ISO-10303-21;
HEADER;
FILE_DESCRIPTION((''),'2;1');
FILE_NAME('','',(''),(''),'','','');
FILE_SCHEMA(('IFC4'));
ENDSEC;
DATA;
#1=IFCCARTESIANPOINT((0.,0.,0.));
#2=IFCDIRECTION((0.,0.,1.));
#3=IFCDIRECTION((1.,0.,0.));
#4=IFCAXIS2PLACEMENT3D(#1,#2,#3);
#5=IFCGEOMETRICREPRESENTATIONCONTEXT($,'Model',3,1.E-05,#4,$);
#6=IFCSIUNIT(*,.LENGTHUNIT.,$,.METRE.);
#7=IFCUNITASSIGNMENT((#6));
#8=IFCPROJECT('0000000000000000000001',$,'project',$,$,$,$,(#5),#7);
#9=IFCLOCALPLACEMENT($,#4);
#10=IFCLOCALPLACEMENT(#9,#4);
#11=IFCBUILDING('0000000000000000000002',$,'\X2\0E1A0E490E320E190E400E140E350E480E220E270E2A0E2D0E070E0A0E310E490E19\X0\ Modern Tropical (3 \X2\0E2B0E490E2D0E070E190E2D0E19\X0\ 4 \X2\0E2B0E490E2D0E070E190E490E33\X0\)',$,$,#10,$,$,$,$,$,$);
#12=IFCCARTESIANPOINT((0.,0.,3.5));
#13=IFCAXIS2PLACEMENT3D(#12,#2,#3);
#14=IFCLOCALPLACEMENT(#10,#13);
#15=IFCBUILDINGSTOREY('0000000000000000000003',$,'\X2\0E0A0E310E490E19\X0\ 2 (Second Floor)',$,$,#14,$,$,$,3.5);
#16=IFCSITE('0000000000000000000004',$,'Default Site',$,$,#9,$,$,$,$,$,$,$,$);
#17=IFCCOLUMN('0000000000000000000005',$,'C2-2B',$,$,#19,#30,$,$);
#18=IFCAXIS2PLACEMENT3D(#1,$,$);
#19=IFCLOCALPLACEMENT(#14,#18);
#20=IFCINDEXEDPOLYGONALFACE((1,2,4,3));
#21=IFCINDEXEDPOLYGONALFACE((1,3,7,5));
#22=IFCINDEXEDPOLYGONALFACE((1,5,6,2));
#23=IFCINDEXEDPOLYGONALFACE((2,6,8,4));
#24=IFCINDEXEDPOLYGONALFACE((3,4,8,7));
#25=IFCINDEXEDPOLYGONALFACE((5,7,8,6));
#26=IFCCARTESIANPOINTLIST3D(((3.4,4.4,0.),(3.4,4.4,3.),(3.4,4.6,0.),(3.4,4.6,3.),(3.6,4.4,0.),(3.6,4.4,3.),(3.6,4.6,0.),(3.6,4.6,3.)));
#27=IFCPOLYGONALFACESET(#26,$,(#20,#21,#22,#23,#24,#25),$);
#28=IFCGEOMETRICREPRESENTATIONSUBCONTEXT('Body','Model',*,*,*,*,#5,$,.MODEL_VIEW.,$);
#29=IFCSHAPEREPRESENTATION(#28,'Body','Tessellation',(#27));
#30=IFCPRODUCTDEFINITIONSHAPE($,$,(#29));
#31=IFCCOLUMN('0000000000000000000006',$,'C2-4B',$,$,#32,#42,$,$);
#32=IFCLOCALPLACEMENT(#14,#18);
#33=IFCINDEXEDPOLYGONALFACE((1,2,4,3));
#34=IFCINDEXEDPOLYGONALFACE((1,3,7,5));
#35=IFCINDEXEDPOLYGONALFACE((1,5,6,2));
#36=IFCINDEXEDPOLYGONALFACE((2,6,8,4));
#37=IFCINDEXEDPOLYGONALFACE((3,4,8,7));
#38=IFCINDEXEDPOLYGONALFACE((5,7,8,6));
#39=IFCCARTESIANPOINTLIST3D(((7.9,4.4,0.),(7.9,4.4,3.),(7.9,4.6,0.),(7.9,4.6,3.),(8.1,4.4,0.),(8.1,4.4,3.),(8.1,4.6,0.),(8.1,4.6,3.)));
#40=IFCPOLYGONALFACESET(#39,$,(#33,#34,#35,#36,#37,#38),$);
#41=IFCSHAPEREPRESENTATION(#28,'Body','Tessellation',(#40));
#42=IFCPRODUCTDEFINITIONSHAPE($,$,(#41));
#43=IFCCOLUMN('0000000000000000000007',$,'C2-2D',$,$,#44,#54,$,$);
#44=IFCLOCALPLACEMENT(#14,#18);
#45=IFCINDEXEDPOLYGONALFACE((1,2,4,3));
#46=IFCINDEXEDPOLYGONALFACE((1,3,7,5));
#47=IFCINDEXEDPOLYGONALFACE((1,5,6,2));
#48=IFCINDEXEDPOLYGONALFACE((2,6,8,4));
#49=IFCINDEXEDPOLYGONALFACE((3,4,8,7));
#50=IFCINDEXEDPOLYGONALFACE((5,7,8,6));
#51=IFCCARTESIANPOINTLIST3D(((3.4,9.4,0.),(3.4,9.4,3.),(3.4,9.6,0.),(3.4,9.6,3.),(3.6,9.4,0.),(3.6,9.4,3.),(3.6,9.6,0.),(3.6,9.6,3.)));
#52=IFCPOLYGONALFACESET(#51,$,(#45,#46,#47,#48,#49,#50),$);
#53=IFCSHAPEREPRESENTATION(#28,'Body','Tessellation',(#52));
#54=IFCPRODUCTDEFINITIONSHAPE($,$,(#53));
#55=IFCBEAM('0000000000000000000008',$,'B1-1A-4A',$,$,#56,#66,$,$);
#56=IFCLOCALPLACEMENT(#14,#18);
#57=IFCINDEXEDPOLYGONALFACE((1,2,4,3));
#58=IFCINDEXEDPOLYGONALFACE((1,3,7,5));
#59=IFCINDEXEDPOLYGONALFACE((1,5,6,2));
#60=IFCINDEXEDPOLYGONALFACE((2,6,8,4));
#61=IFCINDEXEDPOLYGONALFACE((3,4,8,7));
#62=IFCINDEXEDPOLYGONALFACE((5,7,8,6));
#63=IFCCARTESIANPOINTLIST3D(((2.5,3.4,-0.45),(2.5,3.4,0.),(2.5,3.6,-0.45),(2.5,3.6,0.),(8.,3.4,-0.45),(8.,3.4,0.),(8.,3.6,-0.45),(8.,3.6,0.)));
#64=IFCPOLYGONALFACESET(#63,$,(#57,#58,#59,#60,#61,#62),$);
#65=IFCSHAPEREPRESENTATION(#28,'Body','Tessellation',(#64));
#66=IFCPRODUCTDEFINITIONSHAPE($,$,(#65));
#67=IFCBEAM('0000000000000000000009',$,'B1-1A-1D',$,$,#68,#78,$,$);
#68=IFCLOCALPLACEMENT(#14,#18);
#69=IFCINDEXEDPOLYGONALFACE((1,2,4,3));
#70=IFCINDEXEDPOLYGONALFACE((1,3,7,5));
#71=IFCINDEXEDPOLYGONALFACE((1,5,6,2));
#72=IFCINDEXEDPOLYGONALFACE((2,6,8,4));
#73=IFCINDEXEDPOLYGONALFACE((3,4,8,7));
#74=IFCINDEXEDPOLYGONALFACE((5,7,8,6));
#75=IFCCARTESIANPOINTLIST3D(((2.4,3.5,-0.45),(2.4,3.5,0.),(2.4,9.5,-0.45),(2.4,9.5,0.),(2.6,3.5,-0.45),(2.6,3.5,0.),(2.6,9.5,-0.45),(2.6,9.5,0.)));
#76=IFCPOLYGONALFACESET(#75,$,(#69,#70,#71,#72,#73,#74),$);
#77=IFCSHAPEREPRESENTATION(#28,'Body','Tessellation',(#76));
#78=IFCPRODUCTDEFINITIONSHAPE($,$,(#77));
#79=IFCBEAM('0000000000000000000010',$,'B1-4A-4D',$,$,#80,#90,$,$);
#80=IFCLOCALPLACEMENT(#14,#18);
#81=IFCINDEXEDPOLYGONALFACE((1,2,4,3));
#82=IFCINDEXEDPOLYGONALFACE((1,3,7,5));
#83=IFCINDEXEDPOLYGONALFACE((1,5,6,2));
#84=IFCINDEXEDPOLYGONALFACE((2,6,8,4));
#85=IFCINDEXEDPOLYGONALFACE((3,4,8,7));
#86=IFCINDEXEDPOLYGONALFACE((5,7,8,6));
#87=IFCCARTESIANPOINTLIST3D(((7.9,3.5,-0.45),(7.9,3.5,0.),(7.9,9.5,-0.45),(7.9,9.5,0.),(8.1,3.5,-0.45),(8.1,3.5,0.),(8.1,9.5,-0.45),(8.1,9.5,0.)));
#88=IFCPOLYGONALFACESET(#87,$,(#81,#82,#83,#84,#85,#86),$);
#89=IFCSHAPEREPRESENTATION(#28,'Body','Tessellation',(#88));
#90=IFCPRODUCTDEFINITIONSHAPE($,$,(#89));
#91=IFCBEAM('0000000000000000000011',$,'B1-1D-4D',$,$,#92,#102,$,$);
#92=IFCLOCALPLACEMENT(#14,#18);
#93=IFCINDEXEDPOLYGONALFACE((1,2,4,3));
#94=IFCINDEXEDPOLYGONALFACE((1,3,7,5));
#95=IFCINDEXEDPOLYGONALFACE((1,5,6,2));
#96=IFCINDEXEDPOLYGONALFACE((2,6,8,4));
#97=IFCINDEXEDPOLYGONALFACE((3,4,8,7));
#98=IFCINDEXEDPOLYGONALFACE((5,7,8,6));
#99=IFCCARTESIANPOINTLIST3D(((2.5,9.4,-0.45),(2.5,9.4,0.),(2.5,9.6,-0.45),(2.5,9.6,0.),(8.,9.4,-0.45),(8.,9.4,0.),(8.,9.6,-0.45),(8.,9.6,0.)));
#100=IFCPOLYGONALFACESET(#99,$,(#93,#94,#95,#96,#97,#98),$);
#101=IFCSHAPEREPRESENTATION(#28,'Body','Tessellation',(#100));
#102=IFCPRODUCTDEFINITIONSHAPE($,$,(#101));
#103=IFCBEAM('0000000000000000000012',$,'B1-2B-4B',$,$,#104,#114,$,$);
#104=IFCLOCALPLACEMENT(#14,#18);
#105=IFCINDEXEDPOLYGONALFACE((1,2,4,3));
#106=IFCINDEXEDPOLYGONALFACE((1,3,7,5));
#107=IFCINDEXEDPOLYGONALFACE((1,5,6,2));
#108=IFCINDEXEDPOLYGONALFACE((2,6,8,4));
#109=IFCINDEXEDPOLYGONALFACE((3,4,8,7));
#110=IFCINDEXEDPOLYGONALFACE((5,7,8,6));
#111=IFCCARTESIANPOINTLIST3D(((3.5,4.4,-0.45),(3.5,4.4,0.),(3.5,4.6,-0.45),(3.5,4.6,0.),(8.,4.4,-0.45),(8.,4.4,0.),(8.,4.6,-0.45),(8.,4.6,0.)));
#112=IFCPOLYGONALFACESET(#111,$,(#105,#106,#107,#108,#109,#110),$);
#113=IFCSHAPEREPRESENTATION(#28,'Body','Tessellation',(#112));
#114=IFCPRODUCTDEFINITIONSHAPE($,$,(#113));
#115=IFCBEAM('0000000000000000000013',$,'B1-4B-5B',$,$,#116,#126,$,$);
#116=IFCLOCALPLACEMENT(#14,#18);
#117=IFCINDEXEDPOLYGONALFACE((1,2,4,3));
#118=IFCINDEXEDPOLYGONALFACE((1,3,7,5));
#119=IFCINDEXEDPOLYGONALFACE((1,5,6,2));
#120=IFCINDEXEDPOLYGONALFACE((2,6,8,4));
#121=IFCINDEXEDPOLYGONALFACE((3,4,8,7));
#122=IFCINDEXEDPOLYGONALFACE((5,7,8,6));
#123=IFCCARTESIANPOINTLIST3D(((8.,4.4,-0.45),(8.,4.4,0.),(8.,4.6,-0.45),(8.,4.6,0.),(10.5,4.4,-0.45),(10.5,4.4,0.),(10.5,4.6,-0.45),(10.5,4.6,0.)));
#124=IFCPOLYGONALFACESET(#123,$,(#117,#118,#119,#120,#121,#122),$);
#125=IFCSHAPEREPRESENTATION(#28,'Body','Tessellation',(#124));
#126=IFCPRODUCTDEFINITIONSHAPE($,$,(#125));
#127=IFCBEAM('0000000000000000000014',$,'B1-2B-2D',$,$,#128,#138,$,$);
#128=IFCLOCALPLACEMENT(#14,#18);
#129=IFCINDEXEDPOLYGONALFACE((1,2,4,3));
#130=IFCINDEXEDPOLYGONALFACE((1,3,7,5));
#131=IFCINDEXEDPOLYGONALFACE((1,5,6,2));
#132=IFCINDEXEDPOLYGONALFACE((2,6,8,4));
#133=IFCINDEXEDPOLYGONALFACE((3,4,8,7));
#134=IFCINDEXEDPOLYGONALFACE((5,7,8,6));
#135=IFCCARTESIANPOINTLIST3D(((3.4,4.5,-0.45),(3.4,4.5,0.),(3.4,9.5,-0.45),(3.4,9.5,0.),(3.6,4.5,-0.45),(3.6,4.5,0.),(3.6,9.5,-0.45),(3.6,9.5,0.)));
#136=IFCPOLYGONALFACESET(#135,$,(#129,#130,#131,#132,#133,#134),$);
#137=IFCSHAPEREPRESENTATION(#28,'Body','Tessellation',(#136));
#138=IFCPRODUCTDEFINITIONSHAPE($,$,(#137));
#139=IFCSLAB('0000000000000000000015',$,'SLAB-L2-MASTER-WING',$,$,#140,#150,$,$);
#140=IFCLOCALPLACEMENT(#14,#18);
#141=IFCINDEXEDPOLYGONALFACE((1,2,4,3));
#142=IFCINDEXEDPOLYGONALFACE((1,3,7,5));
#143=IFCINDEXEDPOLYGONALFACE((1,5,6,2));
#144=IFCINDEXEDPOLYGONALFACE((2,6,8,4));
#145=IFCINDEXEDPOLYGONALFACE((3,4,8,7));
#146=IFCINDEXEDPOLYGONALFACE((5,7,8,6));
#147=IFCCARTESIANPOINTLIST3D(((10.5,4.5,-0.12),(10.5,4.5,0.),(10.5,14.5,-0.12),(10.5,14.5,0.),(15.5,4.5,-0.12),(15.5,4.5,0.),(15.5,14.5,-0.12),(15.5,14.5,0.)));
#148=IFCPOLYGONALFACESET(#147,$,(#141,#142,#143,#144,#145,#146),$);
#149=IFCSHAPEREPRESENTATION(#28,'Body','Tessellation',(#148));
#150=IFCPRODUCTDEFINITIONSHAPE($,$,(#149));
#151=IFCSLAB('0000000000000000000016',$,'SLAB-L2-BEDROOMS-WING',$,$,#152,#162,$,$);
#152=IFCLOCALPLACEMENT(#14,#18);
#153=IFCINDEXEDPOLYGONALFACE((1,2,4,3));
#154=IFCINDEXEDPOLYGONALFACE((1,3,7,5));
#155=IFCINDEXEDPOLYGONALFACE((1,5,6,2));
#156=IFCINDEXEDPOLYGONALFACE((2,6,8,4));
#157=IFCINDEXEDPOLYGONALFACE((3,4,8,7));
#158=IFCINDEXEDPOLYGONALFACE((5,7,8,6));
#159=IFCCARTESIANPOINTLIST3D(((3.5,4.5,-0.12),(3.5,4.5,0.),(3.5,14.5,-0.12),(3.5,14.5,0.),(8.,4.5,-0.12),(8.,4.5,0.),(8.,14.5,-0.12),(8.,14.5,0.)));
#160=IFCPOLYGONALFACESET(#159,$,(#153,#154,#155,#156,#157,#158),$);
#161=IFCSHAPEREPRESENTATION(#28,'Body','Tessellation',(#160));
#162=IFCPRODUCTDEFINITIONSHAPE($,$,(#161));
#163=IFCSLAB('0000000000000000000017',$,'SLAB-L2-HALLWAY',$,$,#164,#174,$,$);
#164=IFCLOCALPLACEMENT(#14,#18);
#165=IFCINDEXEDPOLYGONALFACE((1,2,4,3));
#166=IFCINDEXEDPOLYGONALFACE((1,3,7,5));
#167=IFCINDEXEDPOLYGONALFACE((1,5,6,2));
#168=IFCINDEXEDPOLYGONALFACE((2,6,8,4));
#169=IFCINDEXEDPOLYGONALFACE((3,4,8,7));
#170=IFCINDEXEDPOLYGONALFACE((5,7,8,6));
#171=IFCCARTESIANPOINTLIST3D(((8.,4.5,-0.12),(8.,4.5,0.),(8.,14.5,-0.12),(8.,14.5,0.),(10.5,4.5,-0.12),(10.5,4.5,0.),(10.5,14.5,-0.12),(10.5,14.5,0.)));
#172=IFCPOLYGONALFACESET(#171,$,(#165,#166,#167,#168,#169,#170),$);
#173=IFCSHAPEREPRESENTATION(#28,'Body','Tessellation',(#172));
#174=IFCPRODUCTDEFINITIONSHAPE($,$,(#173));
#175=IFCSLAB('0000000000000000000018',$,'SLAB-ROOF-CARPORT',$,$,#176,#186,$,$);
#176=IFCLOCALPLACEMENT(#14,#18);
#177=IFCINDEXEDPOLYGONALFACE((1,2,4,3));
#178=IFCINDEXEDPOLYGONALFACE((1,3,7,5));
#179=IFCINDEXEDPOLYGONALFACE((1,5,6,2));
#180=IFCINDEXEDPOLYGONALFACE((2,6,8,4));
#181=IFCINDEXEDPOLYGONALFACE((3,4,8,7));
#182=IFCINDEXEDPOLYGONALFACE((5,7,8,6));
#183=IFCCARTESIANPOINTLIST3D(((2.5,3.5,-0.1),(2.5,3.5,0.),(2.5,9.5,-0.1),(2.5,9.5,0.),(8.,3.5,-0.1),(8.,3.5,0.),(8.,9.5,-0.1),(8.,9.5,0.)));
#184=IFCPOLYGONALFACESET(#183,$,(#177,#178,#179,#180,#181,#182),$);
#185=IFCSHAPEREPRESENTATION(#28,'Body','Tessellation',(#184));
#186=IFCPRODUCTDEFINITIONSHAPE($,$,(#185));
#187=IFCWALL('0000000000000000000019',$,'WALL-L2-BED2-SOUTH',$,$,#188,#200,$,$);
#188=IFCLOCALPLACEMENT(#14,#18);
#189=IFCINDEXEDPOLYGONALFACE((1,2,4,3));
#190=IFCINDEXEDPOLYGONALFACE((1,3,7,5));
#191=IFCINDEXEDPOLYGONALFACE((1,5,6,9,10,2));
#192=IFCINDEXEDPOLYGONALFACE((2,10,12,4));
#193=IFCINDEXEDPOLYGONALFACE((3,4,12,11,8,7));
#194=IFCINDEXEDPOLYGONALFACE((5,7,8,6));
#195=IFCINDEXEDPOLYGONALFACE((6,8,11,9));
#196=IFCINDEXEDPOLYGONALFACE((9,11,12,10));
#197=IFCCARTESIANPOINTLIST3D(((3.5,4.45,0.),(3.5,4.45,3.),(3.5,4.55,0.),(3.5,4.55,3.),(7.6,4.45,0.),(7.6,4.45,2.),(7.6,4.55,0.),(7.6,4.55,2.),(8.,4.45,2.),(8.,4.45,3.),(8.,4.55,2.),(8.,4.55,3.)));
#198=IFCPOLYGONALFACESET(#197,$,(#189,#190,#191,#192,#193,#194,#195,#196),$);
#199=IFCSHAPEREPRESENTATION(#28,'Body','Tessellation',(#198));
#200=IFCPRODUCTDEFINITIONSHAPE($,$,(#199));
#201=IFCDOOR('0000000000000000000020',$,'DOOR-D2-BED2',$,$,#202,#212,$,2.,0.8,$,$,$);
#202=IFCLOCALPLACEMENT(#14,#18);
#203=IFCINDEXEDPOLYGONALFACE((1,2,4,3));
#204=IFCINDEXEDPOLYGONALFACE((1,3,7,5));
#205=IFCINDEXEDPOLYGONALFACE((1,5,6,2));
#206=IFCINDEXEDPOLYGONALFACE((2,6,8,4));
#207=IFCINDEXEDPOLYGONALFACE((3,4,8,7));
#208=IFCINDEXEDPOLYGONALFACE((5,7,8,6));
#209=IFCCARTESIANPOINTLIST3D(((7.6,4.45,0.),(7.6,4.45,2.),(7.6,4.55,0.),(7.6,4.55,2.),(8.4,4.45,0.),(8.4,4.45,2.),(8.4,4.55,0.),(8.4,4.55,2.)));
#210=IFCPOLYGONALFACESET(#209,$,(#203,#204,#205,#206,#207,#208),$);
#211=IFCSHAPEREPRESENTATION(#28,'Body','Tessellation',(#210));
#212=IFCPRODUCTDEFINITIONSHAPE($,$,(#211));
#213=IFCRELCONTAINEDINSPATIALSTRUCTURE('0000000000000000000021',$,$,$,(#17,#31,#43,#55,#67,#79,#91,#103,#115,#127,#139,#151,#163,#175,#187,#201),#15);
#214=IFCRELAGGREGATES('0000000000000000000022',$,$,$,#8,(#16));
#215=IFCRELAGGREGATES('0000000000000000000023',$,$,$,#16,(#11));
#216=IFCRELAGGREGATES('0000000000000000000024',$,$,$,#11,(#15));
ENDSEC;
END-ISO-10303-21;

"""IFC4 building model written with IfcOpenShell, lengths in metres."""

from ifc_helpers import new_model, si_unit, frame, origin_with_axes, origin_2d, place, context, subcontext, project, spatial, polyline, rectangle, outline, extrude, element, fill, save


model = new_model("IFC4")

# Units and contexts
model_context = context("Model", 3, precision=1e-05, world=origin_with_axes())
body_context = subcontext(model_context, "Body", "Model", "MODEL_VIEW")
ifc_project = project(units=[si_unit("LENGTHUNIT", "METRE")], contexts=[model_context])

# Site, building, storey
site_placement = place(None, origin_with_axes())
site = spatial("IfcSite", under=ifc_project, at=site_placement, Name="Default Site")
building_placement = place(site_placement, origin_with_axes())
building = spatial("IfcBuilding", under=site, at=building_placement, Name="บ้านเดี่ยวสองชั้น Modern Tropical (3 ห้องนอน 4 ห้องน้ำ)")
storey_placement = place(building_placement, frame((0.0, 0.0, 3.5), z_axis=(0.0, 0.0, 1.0), x_axis=(1.0, 0.0, 0.0)))
storey = spatial("IfcBuildingStorey", under=building, at=storey_placement, Name="ชั้น 2 (Second Floor)", Elevation=3.5)

# Columns
for number, where, z_axis, x_axis, name in (
    (1, (3.5, 4.5, 0.0), (0.0, 0.0, 1.0), (1.0, 0.0, 0.0), "C2-2B"),
    (2, (8.0, 4.5, 0.0), (0.0, 0.0, 1.0), (1.0, 0.0, 0.0), "C2-4B"),
    (3, (3.5, 9.5, 0.0), (0.0, 0.0, 1.0), (1.0, 0.0, 0.0), "C2-2D"),
):
    element("IfcColumn", number, at=place(storey_placement, frame(where, z_axis=z_axis, x_axis=x_axis)), inside=storey, Name=name, context=body_context, shape_type="SweptSolid", body=[
        extrude(rectangle(XDim=0.2, YDim=0.2, at=origin_2d()), origin_with_axes(), (0.0, 0.0, 1.0), 3.0),
    ])

# Beams
beam_1_placement = place(storey_placement, frame((2.5, 3.5, -0.225), z_axis=(1.0, 0.0, 0.0), x_axis=(0.0, 1.0, 0.0)))
element("IfcBeam", 4, at=beam_1_placement, inside=storey, Name="B1-1A-4A", context=body_context, shape_type="SweptSolid", body=[
    extrude(rectangle(XDim=0.2, YDim=0.45, at=origin_2d()), origin_with_axes(), (0.0, 0.0, 1.0), 5.5),
])
for number, where, z_axis, x_axis, name in (
    (5, (2.5, 3.5, -0.225), (0.0, 1.0, 0.0), (-1.0, 0.0, 0.0), "B1-1A-1D"),
    (6, (8.0, 3.5, -0.225), (0.0, 1.0, 0.0), (-1.0, 0.0, 0.0), "B1-4A-4D"),
):
    element("IfcBeam", number, at=place(storey_placement, frame(where, z_axis=z_axis, x_axis=x_axis)), inside=storey, Name=name, context=body_context, shape_type="SweptSolid", body=[
        extrude(rectangle(XDim=0.2, YDim=0.45, at=origin_2d()), origin_with_axes(), (0.0, 0.0, 1.0), 6.0),
    ])
beam_2_placement = place(storey_placement, frame((2.5, 9.5, -0.225), z_axis=(1.0, 0.0, 0.0), x_axis=(0.0, 1.0, 0.0)))
element("IfcBeam", 7, at=beam_2_placement, inside=storey, Name="B1-1D-4D", context=body_context, shape_type="SweptSolid", body=[
    extrude(rectangle(XDim=0.2, YDim=0.45, at=origin_2d()), origin_with_axes(), (0.0, 0.0, 1.0), 5.5),
])
beam_3_placement = place(storey_placement, frame((3.5, 4.5, -0.225), z_axis=(1.0, 0.0, 0.0), x_axis=(0.0, 1.0, 0.0)))
element("IfcBeam", 8, at=beam_3_placement, inside=storey, Name="B1-2B-4B", context=body_context, shape_type="SweptSolid", body=[
    extrude(rectangle(XDim=0.2, YDim=0.45, at=origin_2d()), origin_with_axes(), (0.0, 0.0, 1.0), 4.5),
])
beam_4_placement = place(storey_placement, frame((8.0, 4.5, -0.225), z_axis=(1.0, 0.0, 0.0), x_axis=(0.0, 1.0, 0.0)))
element("IfcBeam", 9, at=beam_4_placement, inside=storey, Name="B1-4B-5B", context=body_context, shape_type="SweptSolid", body=[
    extrude(rectangle(XDim=0.2, YDim=0.45, at=origin_2d()), origin_with_axes(), (0.0, 0.0, 1.0), 2.5),
])
beam_5_placement = place(storey_placement, frame((3.5, 4.5, -0.225), z_axis=(0.0, 1.0, 0.0), x_axis=(-1.0, 0.0, 0.0)))
element("IfcBeam", 10, at=beam_5_placement, inside=storey, Name="B1-2B-2D", context=body_context, shape_type="SweptSolid", body=[
    extrude(rectangle(XDim=0.2, YDim=0.45, at=origin_2d()), origin_with_axes(), (0.0, 0.0, 1.0), 5.0),
])

# Slabs
slab_1_placement = place(storey_placement, frame((0.0, 0.0, -0.12), z_axis=(0.0, 0.0, 1.0), x_axis=(1.0, 0.0, 0.0)))
element("IfcSlab", 11, at=slab_1_placement, inside=storey, Name="SLAB-L2-MASTER-WING", context=body_context, shape_type="SweptSolid", body=[
    extrude(outline(polyline([(10.5, 4.5), (15.5, 4.5), (15.5, 14.5), (10.5, 14.5), (10.5, 4.5)])), origin_with_axes(), (0.0, 0.0, 1.0), 0.12),
])
slab_2_placement = place(storey_placement, frame((0.0, 0.0, -0.12), z_axis=(0.0, 0.0, 1.0), x_axis=(1.0, 0.0, 0.0)))
element("IfcSlab", 12, at=slab_2_placement, inside=storey, Name="SLAB-L2-BEDROOMS-WING", context=body_context, shape_type="SweptSolid", body=[
    extrude(outline(polyline([(3.5, 4.5), (8.0, 4.5), (8.0, 14.5), (3.5, 14.5), (3.5, 4.5)])), origin_with_axes(), (0.0, 0.0, 1.0), 0.12),
])
slab_3_placement = place(storey_placement, frame((0.0, 0.0, -0.12), z_axis=(0.0, 0.0, 1.0), x_axis=(1.0, 0.0, 0.0)))
element("IfcSlab", 13, at=slab_3_placement, inside=storey, Name="SLAB-L2-HALLWAY", context=body_context, shape_type="SweptSolid", body=[
    extrude(outline(polyline([(8.0, 4.5), (10.5, 4.5), (10.5, 14.5), (8.0, 14.5), (8.0, 4.5)])), origin_with_axes(), (0.0, 0.0, 1.0), 0.12),
])
slab_4_placement = place(storey_placement, frame((0.0, 0.0, -0.1), z_axis=(0.0, 0.0, 1.0), x_axis=(1.0, 0.0, 0.0)))
element("IfcSlab", 14, at=slab_4_placement, inside=storey, Name="SLAB-ROOF-CARPORT", context=body_context, shape_type="SweptSolid", body=[
    extrude(outline(polyline([(2.5, 3.5), (8.0, 3.5), (8.0, 9.5), (2.5, 9.5), (2.5, 3.5)])), origin_with_axes(), (0.0, 0.0, 1.0), 0.1),
])

# Wall, opening, door
wall_1_placement = place(storey_placement, frame((5.75, 4.5, 0.0), z_axis=(0.0, 0.0, 1.0), x_axis=(1.0, 0.0, 0.0)))
wall_1 = element("IfcWall", 15, at=wall_1_placement, inside=storey, Name="WALL-L2-BED2-SOUTH", context=body_context, shape_type="SweptSolid", body=[
    extrude(rectangle(XDim=4.5, YDim=0.1, at=origin_2d()), origin_with_axes(), (0.0, 0.0, 1.0), 3.0),
])
opening_1_placement = place(wall_1_placement, frame((2.25, 0.0, 0.0), z_axis=(0.0, 0.0, 1.0), x_axis=(1.0, 0.0, 0.0)))
opening_1 = element("IfcOpeningElement", 16, at=opening_1_placement, cuts=wall_1, context=body_context, shape_type="SweptSolid", body=[
    extrude(rectangle(XDim=0.8, YDim=0.12, at=origin_2d()), origin_with_axes(), (0.0, 0.0, 1.0), 2.0),
])
door_placement = place(opening_1_placement, origin_with_axes())
door = element("IfcDoor", 17, at=door_placement, inside=storey, Name="DOOR-D2-BED2", OverallHeight=2.0, OverallWidth=0.8, context=body_context, shape_type="SweptSolid", body=[
    extrude(rectangle(XDim=0.8, YDim=0.1, at=origin_2d()), origin_with_axes(), (0.0, 0.0, 1.0), 2.0),
])
fill(opening_1, door)

save(model, "model.ifc")
